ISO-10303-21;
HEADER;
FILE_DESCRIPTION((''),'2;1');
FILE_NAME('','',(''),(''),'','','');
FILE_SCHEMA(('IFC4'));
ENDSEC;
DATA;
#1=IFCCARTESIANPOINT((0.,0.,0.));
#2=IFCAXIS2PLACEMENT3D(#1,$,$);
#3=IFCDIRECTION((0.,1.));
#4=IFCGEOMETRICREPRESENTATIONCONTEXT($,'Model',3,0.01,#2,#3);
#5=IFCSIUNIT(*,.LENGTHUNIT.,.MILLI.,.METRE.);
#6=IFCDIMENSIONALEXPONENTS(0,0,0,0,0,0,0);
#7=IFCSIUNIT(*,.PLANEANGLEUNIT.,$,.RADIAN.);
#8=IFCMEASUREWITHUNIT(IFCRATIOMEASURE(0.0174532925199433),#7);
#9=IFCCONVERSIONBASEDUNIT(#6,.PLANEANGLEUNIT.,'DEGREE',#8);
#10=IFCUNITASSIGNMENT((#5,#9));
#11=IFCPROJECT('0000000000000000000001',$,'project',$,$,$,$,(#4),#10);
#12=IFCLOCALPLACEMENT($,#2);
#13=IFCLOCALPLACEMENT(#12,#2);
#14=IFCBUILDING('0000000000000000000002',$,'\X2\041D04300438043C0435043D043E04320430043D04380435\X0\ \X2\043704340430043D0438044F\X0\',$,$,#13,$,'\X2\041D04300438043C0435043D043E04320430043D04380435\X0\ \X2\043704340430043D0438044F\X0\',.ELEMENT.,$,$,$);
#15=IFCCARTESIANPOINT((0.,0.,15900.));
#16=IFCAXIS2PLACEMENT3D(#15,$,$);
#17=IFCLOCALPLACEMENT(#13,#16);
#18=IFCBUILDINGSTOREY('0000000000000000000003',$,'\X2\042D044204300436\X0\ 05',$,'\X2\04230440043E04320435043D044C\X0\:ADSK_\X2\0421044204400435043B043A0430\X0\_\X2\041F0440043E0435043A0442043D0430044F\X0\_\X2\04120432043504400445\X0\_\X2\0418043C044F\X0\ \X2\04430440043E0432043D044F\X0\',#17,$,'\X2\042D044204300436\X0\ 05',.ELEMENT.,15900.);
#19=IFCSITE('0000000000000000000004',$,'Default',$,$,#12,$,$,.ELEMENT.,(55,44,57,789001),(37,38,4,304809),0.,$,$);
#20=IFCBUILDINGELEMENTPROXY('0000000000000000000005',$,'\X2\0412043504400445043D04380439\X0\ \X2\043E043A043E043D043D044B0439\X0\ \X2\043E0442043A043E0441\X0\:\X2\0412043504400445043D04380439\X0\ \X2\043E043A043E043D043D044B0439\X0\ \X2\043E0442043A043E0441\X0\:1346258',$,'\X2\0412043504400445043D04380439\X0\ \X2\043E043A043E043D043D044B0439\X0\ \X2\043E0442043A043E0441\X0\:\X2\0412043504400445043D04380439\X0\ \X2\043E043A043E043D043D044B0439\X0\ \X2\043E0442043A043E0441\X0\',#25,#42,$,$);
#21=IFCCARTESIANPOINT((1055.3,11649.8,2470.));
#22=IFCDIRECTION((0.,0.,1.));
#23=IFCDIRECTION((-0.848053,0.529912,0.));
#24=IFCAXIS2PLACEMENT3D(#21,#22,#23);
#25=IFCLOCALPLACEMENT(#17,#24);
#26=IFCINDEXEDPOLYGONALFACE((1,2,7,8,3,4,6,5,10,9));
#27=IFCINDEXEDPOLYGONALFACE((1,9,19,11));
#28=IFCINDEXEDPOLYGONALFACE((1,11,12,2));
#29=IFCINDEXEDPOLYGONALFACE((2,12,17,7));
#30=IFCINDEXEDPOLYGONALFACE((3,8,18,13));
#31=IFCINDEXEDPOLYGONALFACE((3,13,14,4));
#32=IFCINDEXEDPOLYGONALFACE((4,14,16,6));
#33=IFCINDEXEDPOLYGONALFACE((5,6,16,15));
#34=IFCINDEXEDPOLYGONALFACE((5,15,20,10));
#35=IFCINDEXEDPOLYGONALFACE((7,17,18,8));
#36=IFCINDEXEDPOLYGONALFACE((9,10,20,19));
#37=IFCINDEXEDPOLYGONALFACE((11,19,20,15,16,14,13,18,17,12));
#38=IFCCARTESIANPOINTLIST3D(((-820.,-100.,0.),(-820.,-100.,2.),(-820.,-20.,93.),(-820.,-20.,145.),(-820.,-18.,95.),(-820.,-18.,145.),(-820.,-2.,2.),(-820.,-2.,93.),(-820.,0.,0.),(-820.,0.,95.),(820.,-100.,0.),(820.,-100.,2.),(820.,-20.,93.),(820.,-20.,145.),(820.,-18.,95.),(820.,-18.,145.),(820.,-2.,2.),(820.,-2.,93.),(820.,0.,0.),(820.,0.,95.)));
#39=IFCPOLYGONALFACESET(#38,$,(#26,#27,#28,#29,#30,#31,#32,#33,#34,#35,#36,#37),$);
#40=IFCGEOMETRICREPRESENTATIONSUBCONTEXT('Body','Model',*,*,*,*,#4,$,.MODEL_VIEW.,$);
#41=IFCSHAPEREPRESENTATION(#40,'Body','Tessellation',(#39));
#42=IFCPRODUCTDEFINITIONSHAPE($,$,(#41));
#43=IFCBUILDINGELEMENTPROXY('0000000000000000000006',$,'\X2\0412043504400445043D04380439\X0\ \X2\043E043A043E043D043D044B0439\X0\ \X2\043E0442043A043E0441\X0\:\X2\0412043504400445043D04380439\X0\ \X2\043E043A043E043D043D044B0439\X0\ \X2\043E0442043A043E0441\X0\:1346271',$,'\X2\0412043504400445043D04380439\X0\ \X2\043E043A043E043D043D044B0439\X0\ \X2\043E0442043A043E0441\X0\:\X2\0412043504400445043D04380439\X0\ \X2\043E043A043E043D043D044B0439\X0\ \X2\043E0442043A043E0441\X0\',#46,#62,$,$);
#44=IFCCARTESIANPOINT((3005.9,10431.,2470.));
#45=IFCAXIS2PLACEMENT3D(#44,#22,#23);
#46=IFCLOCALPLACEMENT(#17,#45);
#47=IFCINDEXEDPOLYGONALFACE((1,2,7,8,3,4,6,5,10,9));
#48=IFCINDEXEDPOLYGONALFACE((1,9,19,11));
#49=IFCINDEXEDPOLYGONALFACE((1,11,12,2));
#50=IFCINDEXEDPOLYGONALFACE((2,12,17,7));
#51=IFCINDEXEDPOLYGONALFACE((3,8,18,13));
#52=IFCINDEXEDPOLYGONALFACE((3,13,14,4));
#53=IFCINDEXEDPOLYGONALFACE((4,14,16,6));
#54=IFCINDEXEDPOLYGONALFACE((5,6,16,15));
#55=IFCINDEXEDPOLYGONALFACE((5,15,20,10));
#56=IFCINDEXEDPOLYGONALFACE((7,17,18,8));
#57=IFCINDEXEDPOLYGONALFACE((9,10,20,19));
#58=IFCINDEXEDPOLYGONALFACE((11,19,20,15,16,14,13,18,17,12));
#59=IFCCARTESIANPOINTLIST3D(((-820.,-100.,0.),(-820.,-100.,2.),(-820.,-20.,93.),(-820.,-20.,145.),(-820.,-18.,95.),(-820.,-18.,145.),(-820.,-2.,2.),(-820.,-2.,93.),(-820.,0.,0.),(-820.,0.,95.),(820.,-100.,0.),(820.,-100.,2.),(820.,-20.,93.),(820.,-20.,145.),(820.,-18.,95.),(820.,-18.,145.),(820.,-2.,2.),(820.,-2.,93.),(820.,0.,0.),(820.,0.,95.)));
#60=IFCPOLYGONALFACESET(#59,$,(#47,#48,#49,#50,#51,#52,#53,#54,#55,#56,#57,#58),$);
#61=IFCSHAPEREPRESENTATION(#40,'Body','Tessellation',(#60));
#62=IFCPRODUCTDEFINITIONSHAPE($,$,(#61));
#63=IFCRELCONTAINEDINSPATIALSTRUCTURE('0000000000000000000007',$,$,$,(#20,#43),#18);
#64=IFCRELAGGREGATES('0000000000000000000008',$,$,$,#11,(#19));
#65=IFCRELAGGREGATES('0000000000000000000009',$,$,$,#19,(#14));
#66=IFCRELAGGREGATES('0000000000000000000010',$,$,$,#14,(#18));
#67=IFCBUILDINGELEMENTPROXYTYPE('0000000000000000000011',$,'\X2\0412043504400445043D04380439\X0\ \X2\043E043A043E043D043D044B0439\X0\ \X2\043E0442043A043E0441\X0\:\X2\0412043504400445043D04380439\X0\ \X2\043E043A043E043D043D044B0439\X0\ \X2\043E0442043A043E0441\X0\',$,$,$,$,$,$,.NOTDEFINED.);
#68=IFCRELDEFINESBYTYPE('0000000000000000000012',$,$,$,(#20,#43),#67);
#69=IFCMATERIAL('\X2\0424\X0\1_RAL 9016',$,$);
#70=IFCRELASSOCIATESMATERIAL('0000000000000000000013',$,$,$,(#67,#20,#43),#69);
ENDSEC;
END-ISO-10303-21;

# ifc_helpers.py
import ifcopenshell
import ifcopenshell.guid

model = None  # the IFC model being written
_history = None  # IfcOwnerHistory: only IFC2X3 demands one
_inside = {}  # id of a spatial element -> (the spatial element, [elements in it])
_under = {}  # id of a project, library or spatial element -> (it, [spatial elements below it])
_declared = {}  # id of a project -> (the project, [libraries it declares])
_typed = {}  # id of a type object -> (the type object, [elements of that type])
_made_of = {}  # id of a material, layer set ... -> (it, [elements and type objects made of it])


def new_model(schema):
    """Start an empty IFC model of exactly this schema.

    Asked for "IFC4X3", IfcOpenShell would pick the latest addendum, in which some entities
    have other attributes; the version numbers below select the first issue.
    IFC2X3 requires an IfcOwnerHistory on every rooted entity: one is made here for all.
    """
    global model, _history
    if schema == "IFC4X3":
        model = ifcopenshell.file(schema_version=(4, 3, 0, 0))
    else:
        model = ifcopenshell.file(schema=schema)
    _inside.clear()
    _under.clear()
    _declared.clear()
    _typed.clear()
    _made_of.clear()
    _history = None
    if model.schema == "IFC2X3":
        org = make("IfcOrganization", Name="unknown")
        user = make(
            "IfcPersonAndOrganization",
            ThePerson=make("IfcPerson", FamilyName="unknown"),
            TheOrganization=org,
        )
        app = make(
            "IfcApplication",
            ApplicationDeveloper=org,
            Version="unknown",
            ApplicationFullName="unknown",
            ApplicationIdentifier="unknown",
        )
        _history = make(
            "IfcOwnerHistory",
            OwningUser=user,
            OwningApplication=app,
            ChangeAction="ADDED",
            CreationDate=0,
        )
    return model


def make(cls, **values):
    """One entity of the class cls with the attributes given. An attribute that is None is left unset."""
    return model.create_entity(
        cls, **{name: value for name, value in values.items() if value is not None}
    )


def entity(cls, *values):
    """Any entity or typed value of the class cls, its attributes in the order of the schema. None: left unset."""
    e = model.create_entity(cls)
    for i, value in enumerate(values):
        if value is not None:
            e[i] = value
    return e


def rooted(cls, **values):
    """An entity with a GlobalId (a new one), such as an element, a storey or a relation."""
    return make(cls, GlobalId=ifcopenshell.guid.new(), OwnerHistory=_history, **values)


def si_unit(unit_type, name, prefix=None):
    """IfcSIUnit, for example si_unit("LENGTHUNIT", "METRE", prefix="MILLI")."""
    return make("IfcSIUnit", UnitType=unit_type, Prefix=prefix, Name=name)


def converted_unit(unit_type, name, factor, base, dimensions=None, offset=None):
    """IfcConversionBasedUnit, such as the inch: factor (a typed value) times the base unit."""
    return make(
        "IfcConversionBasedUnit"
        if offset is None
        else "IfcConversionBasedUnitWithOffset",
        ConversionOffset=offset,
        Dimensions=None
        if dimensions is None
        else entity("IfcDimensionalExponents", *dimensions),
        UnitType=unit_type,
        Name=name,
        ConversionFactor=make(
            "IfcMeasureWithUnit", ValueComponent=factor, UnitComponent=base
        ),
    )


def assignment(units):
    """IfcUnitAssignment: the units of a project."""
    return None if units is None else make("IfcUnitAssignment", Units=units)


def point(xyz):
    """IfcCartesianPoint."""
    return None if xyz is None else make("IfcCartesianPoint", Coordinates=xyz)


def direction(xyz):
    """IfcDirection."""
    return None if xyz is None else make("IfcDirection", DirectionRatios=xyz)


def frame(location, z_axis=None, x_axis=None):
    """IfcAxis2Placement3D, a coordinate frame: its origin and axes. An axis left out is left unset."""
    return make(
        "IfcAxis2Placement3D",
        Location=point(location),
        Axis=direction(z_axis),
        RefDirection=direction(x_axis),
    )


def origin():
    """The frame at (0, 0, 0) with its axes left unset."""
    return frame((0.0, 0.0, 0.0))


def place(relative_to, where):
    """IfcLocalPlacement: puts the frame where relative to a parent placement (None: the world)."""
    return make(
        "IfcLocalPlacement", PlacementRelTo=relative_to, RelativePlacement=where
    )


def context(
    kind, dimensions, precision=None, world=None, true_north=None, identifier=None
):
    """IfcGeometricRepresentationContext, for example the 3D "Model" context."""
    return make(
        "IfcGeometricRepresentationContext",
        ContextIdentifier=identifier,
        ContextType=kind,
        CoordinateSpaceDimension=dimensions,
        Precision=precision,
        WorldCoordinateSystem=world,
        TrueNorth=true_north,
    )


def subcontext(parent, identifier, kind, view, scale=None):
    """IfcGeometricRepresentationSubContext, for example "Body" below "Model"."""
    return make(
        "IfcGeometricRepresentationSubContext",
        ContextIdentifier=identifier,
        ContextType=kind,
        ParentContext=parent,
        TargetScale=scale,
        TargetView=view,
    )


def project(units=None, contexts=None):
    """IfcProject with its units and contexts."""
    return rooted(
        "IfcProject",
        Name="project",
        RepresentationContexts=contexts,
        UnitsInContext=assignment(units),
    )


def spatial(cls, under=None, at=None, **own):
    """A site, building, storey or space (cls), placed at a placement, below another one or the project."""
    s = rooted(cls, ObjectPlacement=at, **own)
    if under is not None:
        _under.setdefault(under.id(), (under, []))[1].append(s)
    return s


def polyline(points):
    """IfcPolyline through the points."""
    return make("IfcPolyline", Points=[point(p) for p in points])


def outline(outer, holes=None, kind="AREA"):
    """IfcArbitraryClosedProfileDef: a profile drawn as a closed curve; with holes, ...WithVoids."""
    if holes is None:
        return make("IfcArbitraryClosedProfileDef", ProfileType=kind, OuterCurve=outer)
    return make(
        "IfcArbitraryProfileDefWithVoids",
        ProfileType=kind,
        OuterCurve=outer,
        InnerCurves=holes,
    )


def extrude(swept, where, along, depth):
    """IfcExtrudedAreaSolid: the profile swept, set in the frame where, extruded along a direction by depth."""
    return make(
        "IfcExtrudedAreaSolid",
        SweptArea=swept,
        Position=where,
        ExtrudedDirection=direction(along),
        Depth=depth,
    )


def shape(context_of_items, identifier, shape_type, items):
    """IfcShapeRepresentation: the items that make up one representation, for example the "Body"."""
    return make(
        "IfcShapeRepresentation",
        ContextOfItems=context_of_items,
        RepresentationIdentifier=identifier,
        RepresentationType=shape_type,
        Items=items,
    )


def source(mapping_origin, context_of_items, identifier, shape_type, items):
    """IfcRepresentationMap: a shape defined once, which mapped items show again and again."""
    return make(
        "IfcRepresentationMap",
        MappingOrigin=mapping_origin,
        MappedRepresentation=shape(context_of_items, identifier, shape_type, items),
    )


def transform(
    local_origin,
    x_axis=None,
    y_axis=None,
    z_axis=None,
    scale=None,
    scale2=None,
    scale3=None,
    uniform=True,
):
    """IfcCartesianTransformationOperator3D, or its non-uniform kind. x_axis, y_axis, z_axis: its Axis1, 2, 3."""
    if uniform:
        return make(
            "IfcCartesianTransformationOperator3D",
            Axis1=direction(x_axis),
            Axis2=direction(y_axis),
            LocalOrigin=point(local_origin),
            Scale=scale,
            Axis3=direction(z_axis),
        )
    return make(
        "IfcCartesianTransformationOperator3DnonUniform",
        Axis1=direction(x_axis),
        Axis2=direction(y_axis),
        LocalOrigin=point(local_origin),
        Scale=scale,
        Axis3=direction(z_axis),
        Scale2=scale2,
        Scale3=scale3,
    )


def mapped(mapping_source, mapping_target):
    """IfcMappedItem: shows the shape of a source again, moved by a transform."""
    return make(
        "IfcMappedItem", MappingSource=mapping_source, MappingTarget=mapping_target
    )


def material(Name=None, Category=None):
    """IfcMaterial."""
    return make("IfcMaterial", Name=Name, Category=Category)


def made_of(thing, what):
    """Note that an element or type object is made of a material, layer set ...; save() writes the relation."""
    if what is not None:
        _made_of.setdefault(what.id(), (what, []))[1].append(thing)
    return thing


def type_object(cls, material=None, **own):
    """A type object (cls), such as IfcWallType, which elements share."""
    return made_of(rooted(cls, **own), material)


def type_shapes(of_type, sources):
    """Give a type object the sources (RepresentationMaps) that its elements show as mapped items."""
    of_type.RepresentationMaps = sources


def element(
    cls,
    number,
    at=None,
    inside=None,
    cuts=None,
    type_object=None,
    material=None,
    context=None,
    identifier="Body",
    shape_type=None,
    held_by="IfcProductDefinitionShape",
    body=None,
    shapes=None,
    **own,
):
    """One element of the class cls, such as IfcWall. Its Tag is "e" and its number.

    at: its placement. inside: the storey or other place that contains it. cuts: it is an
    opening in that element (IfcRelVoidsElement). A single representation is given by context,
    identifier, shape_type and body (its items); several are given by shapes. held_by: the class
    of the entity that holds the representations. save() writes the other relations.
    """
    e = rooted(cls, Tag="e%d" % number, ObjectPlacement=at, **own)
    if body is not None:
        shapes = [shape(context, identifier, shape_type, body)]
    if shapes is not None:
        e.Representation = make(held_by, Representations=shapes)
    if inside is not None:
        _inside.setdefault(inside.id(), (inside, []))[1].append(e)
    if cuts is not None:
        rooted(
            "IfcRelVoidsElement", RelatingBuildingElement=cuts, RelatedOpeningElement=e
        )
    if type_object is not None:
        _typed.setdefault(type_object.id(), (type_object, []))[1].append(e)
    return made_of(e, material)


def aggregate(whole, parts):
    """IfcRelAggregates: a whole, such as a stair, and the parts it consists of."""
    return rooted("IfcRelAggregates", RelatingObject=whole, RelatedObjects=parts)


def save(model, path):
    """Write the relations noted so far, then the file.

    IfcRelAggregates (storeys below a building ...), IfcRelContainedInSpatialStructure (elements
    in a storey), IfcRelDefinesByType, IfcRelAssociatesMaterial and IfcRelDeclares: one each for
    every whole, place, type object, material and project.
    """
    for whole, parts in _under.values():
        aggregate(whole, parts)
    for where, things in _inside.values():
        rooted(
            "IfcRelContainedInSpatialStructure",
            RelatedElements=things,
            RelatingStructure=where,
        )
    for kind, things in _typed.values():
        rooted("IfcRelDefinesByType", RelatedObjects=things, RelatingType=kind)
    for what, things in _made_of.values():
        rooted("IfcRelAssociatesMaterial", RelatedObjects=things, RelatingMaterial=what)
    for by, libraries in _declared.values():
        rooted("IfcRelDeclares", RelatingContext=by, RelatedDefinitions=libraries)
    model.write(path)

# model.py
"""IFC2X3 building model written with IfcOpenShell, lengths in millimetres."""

from ifc_helpers import new_model, entity, si_unit, converted_unit, direction, frame, origin, place, context, subcontext, project, spatial, polyline, outline, extrude, source, transform, mapped, material, type_object, type_shapes, element, save


model = new_model("IFC2X3")

# Units and contexts
model_context = context("Model", 3, precision=0.01, world=origin(), true_north=direction((0.0, 1.0)))
body_context = subcontext(model_context, "Body", "Model", "MODEL_VIEW")
ifc_project = project(units=[si_unit("LENGTHUNIT", "METRE", prefix="MILLI"), converted_unit("PLANEANGLEUNIT", "DEGREE", entity("IfcRatioMeasure", 0.0174532925199433), si_unit("PLANEANGLEUNIT", "RADIAN"), dimensions=[0, 0, 0, 0, 0, 0, 0])], contexts=[model_context])

# Site, building, storey
site_placement = place(None, origin())
site = spatial("IfcSite", under=ifc_project, at=site_placement, Name="Default", CompositionType="ELEMENT", RefLatitude=(55, 44, 57, 789001), RefLongitude=(37, 38, 4, 304809), RefElevation=0.0)
building_placement = place(site_placement, origin())
building = spatial("IfcBuilding", under=site, at=building_placement, Name="Наименование здания", LongName="Наименование здания", CompositionType="ELEMENT")
storey_placement = place(building_placement, frame((0.0, 0.0, 15900.0)))
storey = spatial("IfcBuildingStorey", under=building, at=storey_placement, Name="Этаж 05", ObjectType="Уровень:ADSK_Стрелка_Проектная_Вверх_Имя уровня", LongName="Этаж 05", CompositionType="ELEMENT", Elevation=15900.0)

# Building element proxies
ifc_material_1 = material(Name="Ф1_RAL 9016")
building_element_proxy_type_1 = type_object("IfcBuildingElementProxyType", Name="Верхний оконный откос:Верхний оконный откос", PredefinedType="NOTDEFINED", material=ifc_material_1)
shared_shape_1 = source(origin(), body_context, "Body", "SweptSolid", [
    extrude(outline(polyline([(28.0, -10.0), (78.0, -10.0), (78.0, -8.0), (26.0, -8.0), (26.0, -26.0), (-65.0, -26.0), (-65.0, 72.0), (-67.0, 72.0), (-67.0, -28.0), (28.0, -28.0), (28.0, -10.0)])), frame((-820.0, -28.0, 67.0), z_axis=(1.0, 0.0, 0.0), x_axis=(0.0, 0.0, 1.0)), (0.0, 0.0, 1.0), 1640.0),
])
type_shapes(building_element_proxy_type_1, [shared_shape_1])
for number, where, z_axis, x_axis, name in (
    (1, (1055.3, 11649.8, 2470.0), (0.0, 0.0, 1.0), (-0.848053, 0.529912, 0.0), "Верхний оконный откос:Верхний оконный откос:1346258"),
    (2, (3005.9, 10431.0, 2470.0), (0.0, 0.0, 1.0), (-0.848053, 0.529912, 0.0), "Верхний оконный откос:Верхний оконный откос:1346271"),
):
    element("IfcBuildingElementProxy", number, at=place(storey_placement, frame(where, z_axis=z_axis, x_axis=x_axis)), inside=storey, type_object=building_element_proxy_type_1, material=ifc_material_1, Name=name, ObjectType="Верхний оконный откос:Верхний оконный откос", context=body_context, shape_type="MappedRepresentation", body=[
        mapped(shared_shape_1, transform((0.0, 0.0, 0.0), scale=1.0)),
    ])

save(model, "model.ifc")
